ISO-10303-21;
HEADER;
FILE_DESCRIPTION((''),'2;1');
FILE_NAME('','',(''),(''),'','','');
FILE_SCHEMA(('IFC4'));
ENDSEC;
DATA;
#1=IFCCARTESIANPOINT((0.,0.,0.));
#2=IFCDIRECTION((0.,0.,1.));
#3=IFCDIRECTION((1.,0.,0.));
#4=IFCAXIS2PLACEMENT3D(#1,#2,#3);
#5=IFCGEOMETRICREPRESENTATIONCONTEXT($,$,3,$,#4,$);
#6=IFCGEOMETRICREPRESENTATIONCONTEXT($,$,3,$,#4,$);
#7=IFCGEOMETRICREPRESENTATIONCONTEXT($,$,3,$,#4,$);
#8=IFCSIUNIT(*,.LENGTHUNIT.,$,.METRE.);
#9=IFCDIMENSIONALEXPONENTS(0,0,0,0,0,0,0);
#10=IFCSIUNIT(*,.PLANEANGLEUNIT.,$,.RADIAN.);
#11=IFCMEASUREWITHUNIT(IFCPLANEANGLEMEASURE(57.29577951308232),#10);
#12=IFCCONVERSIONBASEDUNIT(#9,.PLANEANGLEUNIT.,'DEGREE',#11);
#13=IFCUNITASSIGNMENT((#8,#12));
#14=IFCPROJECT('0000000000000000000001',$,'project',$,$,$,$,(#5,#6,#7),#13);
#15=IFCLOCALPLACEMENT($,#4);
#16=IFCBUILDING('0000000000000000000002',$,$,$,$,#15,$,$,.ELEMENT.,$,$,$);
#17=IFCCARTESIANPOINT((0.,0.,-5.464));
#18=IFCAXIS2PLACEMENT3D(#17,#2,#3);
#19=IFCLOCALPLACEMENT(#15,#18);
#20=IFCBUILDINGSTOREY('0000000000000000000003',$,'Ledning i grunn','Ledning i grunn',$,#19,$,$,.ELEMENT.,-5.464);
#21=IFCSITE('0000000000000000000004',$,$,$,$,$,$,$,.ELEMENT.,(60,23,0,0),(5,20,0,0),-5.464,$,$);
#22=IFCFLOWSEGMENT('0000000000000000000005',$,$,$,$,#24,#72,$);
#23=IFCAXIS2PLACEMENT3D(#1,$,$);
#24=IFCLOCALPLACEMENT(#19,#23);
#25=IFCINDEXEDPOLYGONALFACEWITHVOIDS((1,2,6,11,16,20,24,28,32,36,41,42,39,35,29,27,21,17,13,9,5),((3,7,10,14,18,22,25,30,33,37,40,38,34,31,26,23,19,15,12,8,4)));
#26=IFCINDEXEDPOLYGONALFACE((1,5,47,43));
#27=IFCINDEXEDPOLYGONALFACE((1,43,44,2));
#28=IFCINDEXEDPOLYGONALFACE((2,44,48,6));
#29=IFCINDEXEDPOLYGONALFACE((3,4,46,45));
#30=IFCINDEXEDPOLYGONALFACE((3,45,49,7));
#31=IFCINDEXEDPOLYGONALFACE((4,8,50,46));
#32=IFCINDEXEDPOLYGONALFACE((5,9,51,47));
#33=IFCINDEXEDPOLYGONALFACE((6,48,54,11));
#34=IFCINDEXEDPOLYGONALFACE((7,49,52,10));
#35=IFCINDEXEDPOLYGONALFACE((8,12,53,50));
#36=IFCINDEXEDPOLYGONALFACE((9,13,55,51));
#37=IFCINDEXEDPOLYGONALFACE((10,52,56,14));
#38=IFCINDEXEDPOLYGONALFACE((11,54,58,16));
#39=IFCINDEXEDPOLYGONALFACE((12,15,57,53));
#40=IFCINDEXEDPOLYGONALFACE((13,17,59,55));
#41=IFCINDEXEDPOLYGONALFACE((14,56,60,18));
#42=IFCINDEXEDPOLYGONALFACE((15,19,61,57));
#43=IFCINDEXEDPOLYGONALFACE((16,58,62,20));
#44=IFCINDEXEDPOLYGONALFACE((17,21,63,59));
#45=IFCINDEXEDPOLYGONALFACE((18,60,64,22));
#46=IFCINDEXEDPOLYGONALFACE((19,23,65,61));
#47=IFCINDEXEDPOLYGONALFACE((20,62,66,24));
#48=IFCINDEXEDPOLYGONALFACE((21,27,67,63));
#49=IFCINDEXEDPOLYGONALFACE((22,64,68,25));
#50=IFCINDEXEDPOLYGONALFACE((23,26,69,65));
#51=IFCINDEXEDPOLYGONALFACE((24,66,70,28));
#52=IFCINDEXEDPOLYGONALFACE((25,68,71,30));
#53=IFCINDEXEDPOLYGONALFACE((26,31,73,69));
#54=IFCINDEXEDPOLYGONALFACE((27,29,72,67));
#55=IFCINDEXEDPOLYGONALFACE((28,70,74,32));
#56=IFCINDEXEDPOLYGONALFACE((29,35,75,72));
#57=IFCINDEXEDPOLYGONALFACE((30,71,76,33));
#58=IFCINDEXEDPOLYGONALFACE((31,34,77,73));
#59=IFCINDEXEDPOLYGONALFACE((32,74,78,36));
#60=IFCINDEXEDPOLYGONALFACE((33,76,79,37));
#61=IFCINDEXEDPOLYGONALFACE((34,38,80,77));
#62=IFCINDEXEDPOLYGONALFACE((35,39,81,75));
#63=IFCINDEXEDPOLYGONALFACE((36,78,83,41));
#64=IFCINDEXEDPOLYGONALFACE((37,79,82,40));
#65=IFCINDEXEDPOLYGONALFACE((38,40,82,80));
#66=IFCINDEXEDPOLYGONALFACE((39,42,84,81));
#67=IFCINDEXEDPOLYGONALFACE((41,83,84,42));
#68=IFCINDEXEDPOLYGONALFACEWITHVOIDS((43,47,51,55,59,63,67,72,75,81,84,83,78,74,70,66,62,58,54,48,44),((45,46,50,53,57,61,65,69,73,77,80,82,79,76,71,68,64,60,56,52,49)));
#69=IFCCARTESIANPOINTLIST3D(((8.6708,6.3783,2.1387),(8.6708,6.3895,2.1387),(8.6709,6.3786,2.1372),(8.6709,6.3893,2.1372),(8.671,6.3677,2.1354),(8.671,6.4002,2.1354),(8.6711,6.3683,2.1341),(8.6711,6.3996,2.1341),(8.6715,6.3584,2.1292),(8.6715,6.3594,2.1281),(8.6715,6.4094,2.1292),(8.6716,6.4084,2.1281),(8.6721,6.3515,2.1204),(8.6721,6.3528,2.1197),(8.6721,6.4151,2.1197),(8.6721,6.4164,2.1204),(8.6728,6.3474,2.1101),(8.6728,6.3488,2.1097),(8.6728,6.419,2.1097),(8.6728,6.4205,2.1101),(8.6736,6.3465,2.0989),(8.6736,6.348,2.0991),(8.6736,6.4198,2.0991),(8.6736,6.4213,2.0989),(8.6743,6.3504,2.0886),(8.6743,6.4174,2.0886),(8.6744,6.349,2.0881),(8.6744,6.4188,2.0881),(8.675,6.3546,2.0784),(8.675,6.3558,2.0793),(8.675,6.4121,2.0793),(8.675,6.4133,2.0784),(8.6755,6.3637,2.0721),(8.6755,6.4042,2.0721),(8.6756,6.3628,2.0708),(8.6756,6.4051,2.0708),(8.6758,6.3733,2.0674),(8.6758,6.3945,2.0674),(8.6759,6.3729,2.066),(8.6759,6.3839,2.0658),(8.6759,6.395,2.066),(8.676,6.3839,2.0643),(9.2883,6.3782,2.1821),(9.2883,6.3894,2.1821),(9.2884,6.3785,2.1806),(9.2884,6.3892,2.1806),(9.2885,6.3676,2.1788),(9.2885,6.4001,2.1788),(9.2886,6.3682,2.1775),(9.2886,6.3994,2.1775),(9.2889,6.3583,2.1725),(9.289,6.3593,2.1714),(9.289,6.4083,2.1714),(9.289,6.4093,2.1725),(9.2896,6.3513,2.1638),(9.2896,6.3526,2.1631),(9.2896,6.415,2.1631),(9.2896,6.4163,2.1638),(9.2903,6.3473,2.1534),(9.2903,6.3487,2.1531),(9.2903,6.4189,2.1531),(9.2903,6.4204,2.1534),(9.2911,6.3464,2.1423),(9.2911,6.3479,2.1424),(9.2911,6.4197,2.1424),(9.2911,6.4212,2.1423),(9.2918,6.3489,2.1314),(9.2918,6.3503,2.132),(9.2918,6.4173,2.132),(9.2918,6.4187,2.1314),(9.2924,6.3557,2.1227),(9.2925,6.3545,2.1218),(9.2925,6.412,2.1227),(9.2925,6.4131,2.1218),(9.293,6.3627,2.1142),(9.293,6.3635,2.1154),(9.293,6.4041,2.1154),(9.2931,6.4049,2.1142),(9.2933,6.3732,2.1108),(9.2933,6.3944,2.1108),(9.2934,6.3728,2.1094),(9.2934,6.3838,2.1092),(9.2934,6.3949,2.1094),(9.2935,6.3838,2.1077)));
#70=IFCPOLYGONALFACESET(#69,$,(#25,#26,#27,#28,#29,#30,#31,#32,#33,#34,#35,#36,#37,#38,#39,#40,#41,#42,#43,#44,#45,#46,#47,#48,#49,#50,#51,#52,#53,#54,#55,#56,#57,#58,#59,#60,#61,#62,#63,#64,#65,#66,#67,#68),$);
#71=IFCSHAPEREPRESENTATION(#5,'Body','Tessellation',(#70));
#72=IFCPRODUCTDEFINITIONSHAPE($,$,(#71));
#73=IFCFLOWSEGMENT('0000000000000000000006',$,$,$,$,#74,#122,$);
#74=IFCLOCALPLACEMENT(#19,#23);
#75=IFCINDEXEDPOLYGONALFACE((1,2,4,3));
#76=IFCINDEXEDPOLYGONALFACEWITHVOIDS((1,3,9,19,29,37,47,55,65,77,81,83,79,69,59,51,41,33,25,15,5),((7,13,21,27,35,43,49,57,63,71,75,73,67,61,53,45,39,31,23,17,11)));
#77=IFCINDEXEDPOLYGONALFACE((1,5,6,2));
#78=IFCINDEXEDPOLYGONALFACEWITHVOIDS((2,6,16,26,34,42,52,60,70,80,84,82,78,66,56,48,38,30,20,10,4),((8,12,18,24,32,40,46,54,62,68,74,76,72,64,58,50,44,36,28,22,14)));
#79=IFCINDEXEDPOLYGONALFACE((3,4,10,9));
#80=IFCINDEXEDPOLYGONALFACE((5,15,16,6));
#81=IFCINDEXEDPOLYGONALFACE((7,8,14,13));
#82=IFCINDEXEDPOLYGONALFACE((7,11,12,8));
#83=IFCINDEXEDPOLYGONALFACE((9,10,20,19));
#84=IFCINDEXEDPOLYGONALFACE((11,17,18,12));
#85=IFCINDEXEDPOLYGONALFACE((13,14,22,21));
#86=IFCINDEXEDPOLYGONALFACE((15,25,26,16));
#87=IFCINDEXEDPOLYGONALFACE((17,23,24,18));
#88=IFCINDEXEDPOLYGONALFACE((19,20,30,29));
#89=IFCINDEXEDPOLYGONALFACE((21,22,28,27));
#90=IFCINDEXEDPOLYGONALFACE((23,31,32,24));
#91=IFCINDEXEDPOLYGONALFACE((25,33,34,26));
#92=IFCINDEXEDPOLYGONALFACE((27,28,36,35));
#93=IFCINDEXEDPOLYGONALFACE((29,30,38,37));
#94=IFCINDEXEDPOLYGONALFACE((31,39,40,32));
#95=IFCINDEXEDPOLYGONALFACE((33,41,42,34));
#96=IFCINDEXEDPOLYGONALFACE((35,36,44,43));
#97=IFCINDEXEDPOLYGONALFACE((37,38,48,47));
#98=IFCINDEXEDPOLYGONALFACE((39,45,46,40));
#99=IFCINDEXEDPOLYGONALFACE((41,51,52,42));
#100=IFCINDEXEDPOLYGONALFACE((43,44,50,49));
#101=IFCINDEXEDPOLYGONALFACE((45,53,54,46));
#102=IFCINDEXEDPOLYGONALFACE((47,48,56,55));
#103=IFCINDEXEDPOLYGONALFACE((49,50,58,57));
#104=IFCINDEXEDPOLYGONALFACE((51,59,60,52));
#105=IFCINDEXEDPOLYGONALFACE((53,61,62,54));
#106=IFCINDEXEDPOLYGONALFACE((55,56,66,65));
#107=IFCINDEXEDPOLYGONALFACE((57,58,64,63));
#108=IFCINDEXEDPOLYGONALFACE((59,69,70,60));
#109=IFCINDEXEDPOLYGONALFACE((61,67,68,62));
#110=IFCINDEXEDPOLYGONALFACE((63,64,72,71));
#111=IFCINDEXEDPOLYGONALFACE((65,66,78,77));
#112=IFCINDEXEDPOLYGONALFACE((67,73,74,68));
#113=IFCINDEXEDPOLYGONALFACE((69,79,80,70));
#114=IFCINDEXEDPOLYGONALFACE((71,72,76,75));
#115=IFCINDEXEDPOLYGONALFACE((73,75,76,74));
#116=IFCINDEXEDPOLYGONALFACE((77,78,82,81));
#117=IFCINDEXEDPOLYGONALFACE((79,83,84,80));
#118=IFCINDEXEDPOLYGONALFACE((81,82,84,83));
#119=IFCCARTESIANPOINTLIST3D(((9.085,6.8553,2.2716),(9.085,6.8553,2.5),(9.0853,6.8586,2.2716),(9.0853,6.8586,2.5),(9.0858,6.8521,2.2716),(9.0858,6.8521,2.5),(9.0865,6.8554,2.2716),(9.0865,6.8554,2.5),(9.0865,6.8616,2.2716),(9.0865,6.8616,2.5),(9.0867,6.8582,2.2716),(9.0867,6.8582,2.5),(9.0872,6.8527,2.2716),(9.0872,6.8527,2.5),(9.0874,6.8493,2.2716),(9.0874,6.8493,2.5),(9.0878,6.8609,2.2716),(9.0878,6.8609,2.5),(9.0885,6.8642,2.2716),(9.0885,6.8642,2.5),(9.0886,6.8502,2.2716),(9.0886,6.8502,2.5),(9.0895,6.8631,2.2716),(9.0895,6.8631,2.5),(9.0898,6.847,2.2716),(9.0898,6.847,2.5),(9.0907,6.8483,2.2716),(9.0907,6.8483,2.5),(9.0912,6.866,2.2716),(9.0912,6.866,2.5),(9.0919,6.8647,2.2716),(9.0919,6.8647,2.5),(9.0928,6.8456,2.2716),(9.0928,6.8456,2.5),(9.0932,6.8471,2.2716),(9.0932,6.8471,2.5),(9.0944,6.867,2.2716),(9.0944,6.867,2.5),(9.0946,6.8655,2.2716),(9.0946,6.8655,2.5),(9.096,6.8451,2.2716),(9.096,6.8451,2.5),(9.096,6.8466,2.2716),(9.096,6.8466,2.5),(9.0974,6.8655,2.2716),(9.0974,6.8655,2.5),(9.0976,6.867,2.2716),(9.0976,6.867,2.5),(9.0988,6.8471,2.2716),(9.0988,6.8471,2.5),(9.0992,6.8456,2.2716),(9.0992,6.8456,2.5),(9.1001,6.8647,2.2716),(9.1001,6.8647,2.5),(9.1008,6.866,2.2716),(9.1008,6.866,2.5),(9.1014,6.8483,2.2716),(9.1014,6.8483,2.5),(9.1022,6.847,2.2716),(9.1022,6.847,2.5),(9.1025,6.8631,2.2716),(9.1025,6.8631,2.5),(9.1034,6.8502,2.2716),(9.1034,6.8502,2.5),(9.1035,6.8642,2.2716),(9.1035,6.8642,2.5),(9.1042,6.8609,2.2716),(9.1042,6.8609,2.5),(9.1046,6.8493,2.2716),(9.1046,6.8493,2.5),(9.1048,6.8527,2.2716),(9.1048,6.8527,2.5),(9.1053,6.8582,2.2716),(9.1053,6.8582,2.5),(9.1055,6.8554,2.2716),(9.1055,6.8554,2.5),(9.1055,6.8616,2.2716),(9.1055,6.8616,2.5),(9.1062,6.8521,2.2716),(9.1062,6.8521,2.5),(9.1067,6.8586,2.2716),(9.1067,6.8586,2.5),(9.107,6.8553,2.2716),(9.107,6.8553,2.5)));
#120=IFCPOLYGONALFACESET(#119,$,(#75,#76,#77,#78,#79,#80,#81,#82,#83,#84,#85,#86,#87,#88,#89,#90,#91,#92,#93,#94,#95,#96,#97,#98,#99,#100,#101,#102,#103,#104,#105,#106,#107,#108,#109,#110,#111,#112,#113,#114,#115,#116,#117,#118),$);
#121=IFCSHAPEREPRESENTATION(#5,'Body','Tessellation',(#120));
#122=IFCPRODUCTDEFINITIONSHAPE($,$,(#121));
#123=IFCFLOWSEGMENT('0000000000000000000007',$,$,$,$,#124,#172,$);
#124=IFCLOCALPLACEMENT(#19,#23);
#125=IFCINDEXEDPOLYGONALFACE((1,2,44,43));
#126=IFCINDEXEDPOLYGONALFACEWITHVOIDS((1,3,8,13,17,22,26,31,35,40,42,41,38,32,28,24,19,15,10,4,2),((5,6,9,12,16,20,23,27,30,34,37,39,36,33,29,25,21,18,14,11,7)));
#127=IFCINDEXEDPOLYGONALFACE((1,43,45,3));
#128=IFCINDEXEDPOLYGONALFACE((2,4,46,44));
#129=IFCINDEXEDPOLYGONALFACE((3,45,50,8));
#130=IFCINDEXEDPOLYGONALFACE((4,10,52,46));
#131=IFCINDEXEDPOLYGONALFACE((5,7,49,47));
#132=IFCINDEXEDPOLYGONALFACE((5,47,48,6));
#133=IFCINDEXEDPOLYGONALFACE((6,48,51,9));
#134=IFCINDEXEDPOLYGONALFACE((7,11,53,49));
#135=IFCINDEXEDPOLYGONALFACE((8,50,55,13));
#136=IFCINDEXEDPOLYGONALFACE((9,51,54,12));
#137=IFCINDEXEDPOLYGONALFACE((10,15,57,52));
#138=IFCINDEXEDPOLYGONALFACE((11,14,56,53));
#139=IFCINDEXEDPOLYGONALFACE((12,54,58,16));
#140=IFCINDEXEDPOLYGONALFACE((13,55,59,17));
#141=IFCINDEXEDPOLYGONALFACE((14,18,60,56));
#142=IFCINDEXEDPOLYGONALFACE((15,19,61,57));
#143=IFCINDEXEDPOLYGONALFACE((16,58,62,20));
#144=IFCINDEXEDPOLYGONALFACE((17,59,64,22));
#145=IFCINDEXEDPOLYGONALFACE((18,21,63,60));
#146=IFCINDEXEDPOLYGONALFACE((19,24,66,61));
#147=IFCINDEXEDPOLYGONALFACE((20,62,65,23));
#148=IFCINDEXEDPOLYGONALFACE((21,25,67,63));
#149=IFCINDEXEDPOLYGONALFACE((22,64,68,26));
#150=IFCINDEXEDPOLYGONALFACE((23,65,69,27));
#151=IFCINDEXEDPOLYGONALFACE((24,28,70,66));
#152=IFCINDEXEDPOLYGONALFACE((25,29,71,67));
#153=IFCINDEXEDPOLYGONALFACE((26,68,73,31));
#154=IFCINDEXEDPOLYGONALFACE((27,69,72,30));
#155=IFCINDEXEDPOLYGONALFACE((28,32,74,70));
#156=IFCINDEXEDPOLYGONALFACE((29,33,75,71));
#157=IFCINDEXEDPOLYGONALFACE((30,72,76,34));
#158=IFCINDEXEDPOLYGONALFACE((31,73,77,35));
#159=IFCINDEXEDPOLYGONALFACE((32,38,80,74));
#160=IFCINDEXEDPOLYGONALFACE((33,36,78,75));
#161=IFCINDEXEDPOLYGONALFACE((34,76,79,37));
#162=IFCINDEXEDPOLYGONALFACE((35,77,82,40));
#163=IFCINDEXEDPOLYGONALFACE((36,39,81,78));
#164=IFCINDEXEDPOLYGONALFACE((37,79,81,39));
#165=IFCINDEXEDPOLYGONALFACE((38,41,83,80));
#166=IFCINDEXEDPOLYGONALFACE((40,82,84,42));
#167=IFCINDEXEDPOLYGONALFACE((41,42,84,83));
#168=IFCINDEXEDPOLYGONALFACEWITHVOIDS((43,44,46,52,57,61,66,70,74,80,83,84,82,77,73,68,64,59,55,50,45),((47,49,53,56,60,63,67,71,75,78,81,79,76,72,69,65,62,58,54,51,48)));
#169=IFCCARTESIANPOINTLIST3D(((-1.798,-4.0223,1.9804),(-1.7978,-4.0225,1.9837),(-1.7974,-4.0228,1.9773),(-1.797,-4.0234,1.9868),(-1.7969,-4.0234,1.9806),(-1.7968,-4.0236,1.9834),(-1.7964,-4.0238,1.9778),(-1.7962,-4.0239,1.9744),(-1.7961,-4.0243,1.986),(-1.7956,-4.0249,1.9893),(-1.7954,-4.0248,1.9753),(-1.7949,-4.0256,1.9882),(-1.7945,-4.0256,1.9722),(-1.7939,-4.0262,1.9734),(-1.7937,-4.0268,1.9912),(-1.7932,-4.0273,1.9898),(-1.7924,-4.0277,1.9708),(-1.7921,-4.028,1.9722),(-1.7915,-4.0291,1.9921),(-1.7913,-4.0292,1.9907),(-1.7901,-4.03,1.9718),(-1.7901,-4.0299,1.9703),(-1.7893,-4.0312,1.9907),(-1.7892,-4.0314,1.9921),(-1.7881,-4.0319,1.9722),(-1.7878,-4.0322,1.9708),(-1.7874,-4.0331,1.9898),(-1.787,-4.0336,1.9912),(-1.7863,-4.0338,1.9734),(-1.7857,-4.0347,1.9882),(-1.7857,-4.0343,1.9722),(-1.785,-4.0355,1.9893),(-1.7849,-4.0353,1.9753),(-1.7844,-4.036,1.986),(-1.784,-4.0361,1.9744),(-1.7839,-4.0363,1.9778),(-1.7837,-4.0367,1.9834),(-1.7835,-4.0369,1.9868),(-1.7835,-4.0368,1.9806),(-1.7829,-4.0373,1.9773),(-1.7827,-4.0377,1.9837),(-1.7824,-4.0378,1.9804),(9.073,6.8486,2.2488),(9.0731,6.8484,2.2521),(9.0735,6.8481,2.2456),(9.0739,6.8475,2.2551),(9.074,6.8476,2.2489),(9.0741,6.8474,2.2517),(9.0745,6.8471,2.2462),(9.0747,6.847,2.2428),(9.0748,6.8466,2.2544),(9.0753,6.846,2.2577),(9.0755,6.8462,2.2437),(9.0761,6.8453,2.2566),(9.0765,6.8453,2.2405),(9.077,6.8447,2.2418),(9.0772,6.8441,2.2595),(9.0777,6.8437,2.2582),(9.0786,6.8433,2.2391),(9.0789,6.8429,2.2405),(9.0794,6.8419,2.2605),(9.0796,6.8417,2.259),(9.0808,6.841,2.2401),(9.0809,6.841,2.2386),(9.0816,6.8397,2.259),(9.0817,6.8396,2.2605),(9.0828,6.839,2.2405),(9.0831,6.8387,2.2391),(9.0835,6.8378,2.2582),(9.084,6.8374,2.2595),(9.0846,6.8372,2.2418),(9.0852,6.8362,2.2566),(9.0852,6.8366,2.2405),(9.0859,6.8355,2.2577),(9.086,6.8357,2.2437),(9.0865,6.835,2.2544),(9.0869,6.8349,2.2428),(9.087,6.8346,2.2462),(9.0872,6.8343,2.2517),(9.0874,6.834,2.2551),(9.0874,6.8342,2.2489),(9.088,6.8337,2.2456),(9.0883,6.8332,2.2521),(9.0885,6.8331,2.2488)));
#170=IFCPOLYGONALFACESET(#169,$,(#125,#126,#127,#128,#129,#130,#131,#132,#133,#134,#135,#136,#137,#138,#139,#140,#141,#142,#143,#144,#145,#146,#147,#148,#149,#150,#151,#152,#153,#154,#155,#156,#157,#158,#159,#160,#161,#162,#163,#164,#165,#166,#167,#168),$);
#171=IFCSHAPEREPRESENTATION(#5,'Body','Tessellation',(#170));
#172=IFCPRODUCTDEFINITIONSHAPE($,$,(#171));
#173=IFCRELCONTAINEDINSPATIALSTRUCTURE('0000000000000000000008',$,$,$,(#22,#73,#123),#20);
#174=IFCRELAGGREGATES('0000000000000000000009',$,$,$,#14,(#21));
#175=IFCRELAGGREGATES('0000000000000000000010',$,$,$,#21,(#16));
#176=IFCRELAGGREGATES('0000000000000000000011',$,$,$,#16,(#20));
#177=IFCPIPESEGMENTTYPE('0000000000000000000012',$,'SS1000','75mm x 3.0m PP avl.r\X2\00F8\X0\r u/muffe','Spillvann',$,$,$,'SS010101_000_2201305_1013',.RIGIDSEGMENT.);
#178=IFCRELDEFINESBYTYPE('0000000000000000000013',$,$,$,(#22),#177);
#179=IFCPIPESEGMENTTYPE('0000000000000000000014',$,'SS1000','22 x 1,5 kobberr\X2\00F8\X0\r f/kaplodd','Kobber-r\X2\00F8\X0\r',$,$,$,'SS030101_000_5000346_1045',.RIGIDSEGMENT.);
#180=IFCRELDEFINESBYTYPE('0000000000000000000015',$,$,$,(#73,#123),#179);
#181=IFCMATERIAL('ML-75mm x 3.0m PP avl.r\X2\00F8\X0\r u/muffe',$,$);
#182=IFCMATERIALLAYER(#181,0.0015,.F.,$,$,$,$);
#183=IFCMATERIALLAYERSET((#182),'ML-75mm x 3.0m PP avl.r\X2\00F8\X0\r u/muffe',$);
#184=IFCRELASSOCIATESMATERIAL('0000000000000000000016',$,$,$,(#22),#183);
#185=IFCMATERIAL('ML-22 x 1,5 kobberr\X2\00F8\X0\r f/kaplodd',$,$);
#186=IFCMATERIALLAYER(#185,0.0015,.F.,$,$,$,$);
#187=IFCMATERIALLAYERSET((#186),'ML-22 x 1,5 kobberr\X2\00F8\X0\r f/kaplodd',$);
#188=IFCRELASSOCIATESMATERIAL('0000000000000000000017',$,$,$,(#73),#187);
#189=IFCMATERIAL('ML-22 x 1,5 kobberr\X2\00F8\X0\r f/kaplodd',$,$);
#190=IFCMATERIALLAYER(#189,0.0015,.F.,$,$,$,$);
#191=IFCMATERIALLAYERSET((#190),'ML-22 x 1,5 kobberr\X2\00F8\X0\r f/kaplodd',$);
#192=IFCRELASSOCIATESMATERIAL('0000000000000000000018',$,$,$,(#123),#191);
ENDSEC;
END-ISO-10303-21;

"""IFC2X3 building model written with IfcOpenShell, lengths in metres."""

from ifc_helpers import new_model, entity, si_unit, converted_unit, frame, origin_with_axes, origin_2d_with_axis, place, context, project, spatial, hollow_circle, extrude, material, layer, layer_set, layer_usage, type_object, element, save


model = new_model("IFC2X3")

# Units and contexts
context_of_model_1 = context(None, 3, world=origin_with_axes())
context_of_model_2 = context(None, 3, world=origin_with_axes())
context_of_model_3 = context(None, 3, world=origin_with_axes())
ifc_project = project(units=[si_unit("LENGTHUNIT", "METRE"), converted_unit("PLANEANGLEUNIT", "DEGREE", entity("IfcPlaneAngleMeasure", 57.29577951308232), si_unit("PLANEANGLEUNIT", "RADIAN"), dimensions=[0, 0, 0, 0, 0, 0, 0])], contexts=[context_of_model_1, context_of_model_2, context_of_model_3])

# Site, building, storey
site = spatial("IfcSite", under=ifc_project, CompositionType="ELEMENT", RefLatitude=(60, 23, 0, 0), RefLongitude=(5, 20, 0, 0), RefElevation=-5.464)
building_placement = place(None, origin_with_axes())
building = spatial("IfcBuilding", under=site, at=building_placement, CompositionType="ELEMENT")
storey_placement = place(building_placement, frame((0.0, 0.0, -5.464), z_axis=(0.0, 0.0, 1.0), x_axis=(1.0, 0.0, 0.0)))
storey = spatial("IfcBuildingStorey", under=building, at=storey_placement, Name="Ledning i grunn", Description="Ledning i grunn", CompositionType="ELEMENT", Elevation=-5.464)

# Flow segments
pipe_segment_type_1 = type_object("IfcPipeSegmentType", Name="SS1000", Description="75mm x 3.0m PP avl.rør u/muffe", ApplicableOccurrence="Spillvann", ElementType="SS010101_000_2201305_1013", PredefinedType="RIGIDSEGMENT")
ifc_material_1 = material(Name="ML-75mm x 3.0m PP avl.rør u/muffe")
ifc_layer_1 = layer(ifc_material_1, 0.0015, ventilated=False)
ifc_layer_set_1 = layer_set([ifc_layer_1], Name="ML-75mm x 3.0m PP avl.rør u/muffe")
ifc_layer_usage_1 = layer_usage(ifc_layer_set_1, "AXIS2", "POSITIVE", 0.0)
flow_segment_1_placement = place(storey_placement, frame((9.2909, 6.3838, 2.1451), z_axis=(-0.997543, 0.000179, -0.070058), x_axis=(0.070058, -0.000013, -0.997543)))
element("IfcFlowSegment", 1, at=flow_segment_1_placement, inside=storey, type_object=pipe_segment_type_1, material=ifc_layer_usage_1, context=context_of_model_1, shape_type="SweptSolid", body=[
    extrude(hollow_circle(Radius=0.0375, WallThickness=0.0015, at=origin_2d_with_axis()), origin_with_axes(), (0.0, 0.0, 1.0), 0.619),
])
ifc_material_2 = material(Name="ML-22 x 1,5 kobberrør f/kaplodd")
ifc_layer_2 = layer(ifc_material_2, 0.0015, ventilated=False)
ifc_layer_set_2 = layer_set([ifc_layer_2], Name="ML-22 x 1,5 kobberrør f/kaplodd")
ifc_layer_usage_2 = layer_usage(ifc_layer_set_2, "AXIS2", "POSITIVE", 0.0)
pipe_segment_type_2 = type_object("IfcPipeSegmentType", Name="SS1000", Description="22 x 1,5 kobberrør f/kaplodd", ApplicableOccurrence="Kobber-rør", ElementType="SS030101_000_5000346_1045", PredefinedType="RIGIDSEGMENT")
flow_segment_2_placement = place(storey_placement, frame((9.096, 6.8561, 2.5), z_axis=(0.0, 0.0, -1.0), x_axis=(0.0, -1.0, 0.0)))
element("IfcFlowSegment", 2, at=flow_segment_2_placement, inside=storey, type_object=pipe_segment_type_2, material=ifc_layer_usage_2, context=context_of_model_1, shape_type="SweptSolid", body=[
    extrude(hollow_circle(Radius=0.011, WallThickness=0.0015, at=origin_2d_with_axis()), origin_with_axes(), (0.0, 0.0, 1.0), 0.2284),
])
ifc_material_3 = material(Name="ML-22 x 1,5 kobberrør f/kaplodd")
ifc_layer_3 = layer(ifc_material_3, 0.0015, ventilated=False)
ifc_layer_set_3 = layer_set([ifc_layer_3], Name="ML-22 x 1,5 kobberrør f/kaplodd")
ifc_layer_usage_3 = layer_usage(ifc_layer_set_3, "AXIS2", "POSITIVE", 0.0)
flow_segment_3_placement = place(storey_placement, frame((9.0807, 6.8408, 2.2496), z_axis=(-0.706999, -0.706999, -0.017452), x_axis=(0.012341, 0.012341, -0.999848)))
element("IfcFlowSegment", 3, at=flow_segment_3_placement, inside=storey, type_object=pipe_segment_type_2, material=ifc_layer_usage_3, context=context_of_model_1, shape_type="SweptSolid", body=[
    extrude(hollow_circle(Radius=0.011, WallThickness=0.0015, at=origin_2d_with_axis()), origin_with_axes(), (0.0, 0.0, 1.0), 15.3762),
])

save(model, "model.ifc")
